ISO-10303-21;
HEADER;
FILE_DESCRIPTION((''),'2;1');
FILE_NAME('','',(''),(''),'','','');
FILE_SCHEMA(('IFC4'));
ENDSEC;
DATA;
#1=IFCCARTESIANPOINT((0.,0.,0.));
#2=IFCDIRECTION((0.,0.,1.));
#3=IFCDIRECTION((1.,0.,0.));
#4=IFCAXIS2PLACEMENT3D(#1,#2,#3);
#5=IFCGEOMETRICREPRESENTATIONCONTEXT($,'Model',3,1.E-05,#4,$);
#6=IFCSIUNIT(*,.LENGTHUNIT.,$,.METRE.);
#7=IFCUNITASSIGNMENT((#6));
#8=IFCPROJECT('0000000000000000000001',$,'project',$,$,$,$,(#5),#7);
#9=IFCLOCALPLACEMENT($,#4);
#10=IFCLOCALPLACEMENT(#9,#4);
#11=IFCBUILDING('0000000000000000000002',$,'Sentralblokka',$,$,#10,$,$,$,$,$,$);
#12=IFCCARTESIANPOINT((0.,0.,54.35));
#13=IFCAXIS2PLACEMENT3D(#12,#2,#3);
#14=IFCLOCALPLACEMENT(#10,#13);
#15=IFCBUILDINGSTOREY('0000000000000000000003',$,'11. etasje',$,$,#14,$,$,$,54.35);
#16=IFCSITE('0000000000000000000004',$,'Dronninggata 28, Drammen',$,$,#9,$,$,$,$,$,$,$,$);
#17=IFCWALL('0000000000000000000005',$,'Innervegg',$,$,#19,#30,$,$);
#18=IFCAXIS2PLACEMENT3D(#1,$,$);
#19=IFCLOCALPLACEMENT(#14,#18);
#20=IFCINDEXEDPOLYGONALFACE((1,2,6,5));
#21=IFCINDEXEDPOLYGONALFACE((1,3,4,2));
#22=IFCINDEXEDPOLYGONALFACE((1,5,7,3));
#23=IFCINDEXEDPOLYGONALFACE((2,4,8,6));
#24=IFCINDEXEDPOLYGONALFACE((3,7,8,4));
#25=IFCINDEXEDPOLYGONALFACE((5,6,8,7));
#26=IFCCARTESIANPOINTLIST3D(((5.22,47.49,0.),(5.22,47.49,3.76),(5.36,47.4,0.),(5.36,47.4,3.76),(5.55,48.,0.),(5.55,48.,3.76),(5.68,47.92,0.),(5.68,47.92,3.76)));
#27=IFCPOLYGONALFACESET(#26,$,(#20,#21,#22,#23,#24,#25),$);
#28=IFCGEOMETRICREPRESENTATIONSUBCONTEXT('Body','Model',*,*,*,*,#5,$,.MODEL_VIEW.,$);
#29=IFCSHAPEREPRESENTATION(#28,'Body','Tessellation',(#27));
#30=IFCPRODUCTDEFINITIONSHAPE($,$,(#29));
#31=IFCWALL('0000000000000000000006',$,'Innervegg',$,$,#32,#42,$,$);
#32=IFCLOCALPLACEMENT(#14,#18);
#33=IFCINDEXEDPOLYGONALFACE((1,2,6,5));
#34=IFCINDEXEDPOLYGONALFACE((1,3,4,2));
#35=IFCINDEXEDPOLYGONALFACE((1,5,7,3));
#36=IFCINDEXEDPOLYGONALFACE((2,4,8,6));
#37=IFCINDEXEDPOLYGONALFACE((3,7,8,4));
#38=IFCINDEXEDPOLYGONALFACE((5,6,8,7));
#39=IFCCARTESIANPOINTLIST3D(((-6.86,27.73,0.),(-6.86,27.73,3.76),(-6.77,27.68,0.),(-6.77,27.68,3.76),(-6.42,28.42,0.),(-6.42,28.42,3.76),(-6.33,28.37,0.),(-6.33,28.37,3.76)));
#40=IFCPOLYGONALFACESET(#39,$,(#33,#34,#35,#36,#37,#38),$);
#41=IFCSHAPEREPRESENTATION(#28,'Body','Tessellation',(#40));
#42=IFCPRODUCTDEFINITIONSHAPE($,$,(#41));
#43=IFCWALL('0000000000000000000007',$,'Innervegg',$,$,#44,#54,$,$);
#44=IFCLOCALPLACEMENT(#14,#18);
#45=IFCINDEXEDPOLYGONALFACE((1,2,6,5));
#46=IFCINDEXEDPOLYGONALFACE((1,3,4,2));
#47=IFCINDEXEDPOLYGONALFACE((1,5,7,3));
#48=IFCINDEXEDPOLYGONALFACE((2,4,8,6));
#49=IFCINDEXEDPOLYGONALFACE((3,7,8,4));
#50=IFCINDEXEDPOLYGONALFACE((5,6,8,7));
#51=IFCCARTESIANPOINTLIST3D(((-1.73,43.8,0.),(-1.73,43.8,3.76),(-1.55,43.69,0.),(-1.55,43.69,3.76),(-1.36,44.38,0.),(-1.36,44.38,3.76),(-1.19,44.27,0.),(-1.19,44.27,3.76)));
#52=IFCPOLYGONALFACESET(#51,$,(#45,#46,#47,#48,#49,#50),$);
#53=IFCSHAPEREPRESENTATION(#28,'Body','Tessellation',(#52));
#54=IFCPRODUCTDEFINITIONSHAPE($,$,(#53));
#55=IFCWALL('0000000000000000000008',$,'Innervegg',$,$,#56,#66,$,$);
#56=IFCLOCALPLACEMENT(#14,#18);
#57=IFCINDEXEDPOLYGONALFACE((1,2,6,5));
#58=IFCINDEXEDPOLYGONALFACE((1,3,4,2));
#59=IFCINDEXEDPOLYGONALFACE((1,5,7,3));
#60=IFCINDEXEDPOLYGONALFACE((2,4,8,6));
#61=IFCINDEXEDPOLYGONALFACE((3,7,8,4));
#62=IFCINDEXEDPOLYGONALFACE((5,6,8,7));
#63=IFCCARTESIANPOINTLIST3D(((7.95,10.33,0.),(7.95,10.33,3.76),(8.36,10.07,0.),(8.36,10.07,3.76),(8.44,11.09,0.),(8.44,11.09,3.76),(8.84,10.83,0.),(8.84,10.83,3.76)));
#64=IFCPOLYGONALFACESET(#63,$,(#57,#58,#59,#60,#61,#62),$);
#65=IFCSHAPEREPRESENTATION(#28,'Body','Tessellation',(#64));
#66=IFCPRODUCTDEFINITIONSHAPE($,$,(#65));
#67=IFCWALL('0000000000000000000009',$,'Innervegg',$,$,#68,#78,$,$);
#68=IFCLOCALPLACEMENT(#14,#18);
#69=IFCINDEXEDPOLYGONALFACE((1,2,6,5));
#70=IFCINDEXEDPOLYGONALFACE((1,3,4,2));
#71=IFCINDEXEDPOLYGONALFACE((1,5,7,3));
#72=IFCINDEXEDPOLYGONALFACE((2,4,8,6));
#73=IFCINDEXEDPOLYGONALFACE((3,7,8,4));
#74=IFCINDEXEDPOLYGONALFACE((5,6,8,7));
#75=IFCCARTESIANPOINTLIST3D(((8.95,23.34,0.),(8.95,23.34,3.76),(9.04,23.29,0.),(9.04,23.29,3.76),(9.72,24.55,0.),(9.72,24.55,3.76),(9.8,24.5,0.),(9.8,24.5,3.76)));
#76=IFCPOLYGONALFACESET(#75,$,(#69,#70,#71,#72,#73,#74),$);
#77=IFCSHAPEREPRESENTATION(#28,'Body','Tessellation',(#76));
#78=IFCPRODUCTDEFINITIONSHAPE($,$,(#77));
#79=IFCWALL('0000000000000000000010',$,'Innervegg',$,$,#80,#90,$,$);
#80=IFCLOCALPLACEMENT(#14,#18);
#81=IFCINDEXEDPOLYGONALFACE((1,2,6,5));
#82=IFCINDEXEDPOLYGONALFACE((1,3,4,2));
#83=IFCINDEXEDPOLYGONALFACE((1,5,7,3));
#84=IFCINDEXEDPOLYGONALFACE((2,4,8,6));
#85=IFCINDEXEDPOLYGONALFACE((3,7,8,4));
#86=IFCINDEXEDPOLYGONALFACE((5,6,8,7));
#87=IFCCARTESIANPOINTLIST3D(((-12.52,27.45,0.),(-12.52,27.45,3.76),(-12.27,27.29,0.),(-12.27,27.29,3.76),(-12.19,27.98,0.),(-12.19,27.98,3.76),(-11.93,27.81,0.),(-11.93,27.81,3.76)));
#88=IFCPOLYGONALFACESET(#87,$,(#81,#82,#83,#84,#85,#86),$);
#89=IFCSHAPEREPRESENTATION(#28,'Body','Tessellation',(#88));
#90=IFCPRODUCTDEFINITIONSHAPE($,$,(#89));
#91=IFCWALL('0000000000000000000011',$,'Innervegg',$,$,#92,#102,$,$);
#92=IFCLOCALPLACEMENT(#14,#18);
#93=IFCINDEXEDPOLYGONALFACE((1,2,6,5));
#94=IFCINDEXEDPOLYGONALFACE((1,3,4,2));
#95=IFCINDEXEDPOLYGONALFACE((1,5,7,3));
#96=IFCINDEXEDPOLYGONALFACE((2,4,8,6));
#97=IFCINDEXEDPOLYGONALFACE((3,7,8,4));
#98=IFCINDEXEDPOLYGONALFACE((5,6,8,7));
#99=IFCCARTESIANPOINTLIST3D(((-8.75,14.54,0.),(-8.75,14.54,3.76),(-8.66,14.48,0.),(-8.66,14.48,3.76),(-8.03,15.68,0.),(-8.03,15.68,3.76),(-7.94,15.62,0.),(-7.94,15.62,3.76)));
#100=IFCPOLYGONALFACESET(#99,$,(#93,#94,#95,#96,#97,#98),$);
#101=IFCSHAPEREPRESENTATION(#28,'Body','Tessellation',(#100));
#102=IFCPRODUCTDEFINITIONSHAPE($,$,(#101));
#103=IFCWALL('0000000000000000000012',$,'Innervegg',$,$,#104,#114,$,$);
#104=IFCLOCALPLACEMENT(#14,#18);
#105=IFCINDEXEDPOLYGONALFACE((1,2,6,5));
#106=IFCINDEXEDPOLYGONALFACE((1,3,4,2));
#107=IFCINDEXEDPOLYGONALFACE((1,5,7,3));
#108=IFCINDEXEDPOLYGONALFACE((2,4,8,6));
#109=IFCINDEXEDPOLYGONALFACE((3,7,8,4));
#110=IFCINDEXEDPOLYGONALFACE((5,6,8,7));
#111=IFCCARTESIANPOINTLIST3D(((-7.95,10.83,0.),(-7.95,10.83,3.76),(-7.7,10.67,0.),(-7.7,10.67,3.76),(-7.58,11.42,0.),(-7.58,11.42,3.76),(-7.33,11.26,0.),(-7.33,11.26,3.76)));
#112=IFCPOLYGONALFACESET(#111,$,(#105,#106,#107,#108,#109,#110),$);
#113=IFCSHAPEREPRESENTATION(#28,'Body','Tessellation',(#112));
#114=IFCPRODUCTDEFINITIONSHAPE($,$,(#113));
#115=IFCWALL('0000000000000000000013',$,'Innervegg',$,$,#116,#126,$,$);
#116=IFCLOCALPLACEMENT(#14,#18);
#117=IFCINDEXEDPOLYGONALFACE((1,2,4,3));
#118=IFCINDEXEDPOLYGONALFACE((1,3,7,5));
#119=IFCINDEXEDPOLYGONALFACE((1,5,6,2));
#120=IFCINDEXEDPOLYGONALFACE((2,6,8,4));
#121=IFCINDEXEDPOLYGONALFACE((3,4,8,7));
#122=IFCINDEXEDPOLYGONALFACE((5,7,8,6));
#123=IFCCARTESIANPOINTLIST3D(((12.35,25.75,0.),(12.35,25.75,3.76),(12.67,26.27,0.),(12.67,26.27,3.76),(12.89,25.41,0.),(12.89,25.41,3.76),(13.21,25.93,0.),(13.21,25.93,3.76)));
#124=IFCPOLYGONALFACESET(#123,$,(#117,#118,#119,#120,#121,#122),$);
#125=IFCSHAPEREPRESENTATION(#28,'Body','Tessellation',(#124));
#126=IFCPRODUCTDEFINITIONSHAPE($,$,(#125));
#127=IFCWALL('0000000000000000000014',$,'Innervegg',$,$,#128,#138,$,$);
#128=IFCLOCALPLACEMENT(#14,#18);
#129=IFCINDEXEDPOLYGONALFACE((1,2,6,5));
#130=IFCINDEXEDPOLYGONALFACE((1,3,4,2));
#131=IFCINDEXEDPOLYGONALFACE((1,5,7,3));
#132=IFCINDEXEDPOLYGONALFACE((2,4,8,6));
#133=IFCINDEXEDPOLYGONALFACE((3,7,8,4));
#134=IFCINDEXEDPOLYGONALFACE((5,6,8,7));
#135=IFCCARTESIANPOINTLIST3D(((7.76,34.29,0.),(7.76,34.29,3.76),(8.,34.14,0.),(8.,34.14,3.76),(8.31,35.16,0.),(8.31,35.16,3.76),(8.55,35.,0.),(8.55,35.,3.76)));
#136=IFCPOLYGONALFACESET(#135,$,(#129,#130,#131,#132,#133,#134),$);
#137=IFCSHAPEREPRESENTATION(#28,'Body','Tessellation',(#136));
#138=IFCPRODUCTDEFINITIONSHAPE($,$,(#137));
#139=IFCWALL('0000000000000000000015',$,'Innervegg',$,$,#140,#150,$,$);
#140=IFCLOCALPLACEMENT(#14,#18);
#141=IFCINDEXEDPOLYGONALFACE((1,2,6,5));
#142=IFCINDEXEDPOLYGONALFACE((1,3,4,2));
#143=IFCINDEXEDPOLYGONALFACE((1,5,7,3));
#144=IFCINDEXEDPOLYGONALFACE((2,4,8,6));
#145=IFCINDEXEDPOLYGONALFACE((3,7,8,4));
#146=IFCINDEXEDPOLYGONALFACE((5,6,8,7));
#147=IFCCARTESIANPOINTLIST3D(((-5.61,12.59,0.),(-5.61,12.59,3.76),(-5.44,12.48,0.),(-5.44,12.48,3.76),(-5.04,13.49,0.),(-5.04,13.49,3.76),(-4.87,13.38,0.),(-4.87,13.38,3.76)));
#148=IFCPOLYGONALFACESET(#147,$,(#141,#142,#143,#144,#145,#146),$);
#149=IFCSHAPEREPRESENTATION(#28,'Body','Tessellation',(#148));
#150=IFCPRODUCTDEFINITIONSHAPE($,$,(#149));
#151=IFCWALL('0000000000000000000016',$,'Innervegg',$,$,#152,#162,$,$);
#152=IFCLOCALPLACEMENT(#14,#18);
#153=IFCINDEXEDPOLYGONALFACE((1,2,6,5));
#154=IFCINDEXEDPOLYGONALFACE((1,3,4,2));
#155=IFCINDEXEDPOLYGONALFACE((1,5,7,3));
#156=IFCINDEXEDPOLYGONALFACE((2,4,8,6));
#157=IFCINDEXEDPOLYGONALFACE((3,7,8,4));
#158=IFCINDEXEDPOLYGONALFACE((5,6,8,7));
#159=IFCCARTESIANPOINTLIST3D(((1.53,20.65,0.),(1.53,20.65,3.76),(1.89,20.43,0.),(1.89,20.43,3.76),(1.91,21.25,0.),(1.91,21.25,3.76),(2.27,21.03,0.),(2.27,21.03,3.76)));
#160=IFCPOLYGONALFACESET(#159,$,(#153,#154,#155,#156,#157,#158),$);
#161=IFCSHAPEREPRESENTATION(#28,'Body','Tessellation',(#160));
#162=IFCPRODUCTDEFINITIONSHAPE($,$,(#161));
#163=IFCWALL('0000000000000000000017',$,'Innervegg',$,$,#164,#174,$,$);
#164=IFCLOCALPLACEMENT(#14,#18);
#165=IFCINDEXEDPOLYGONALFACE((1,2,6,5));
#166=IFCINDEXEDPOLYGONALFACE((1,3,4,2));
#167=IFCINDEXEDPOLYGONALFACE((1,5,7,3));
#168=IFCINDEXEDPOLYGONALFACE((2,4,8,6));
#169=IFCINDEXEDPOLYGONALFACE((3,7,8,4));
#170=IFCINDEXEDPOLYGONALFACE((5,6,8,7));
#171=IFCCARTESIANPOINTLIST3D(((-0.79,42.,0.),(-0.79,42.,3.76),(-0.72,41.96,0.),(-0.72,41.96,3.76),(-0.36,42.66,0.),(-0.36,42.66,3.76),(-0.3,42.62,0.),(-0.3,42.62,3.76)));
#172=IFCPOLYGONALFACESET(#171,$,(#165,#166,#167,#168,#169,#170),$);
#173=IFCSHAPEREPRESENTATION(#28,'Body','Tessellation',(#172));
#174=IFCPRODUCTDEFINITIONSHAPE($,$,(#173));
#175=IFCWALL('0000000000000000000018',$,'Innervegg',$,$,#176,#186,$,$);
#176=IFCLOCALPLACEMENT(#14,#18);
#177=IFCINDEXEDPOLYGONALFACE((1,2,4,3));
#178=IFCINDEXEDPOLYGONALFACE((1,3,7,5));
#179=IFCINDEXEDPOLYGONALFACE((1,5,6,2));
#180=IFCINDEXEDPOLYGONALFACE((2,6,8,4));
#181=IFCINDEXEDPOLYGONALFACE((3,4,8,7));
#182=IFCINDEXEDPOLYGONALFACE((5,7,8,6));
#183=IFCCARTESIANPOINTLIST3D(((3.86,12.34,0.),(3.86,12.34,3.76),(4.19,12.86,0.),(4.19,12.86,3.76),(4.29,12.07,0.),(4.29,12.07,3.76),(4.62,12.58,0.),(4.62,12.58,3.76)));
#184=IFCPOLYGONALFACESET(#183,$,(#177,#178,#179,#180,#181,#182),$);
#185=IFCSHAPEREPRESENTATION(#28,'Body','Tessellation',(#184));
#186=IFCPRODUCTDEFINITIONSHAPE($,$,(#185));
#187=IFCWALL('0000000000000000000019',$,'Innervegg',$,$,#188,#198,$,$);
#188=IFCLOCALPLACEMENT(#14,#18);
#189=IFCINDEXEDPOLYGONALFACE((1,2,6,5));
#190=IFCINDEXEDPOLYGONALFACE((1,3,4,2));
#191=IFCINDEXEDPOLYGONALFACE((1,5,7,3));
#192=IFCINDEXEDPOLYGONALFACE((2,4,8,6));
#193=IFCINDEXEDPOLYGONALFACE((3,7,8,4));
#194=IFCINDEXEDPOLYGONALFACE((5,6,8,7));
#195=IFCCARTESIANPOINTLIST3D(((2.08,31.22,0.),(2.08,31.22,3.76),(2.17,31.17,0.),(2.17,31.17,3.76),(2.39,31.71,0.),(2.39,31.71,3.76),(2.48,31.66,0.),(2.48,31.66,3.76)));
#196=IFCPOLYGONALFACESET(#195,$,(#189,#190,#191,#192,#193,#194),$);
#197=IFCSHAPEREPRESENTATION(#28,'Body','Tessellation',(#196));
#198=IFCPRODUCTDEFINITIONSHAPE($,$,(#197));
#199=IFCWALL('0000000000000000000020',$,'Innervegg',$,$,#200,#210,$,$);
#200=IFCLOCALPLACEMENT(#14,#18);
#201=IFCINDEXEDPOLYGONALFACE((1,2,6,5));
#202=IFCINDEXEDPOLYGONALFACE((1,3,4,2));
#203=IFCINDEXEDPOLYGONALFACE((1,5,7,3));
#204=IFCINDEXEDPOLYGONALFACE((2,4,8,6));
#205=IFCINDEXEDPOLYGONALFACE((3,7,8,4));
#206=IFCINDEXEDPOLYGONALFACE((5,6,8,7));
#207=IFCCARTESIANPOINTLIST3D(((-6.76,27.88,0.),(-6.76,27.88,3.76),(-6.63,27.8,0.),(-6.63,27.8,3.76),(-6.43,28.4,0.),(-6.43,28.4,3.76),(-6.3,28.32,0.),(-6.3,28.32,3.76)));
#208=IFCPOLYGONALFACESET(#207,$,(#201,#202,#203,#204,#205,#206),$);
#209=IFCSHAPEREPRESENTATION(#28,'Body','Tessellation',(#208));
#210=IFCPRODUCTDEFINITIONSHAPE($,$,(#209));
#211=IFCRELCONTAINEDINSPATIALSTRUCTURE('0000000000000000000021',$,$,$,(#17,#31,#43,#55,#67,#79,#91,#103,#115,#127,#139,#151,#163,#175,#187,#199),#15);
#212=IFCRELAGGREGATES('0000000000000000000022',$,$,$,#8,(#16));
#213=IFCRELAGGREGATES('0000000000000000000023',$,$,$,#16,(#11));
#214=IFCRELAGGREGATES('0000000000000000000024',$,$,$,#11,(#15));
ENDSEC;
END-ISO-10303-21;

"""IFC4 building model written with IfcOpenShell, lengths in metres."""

from ifc_helpers import new_model, si_unit, frame, origin_with_axes, place, context, subcontext, project, spatial, polyline, outline, extrude, element, save


model = new_model("IFC4")

# Units and contexts
model_context = context("Model", 3, precision=1e-05, world=origin_with_axes())
body_context = subcontext(model_context, "Body", "Model", "MODEL_VIEW")
ifc_project = project(units=[si_unit("LENGTHUNIT", "METRE")], contexts=[model_context])

# Site, building, storey
site_placement = place(None, origin_with_axes())
site = spatial("IfcSite", under=ifc_project, at=site_placement, Name="Dronninggata 28, Drammen")
building_placement = place(site_placement, origin_with_axes())
building = spatial("IfcBuilding", under=site, at=building_placement, Name="Sentralblokka")
storey_placement = place(building_placement, frame((0.0, 0.0, 54.35), z_axis=(0.0, 0.0, 1.0), x_axis=(1.0, 0.0, 0.0)))
storey = spatial("IfcBuildingStorey", under=building, at=storey_placement, Name="11. etasje", Elevation=54.35)

# Walls
wall_1_placement = place(storey_placement, frame((0.0, 0.0, -54.35), z_axis=(0.0, 0.0, 1.0), x_axis=(1.0, 0.0, 0.0)))
element("IfcWall", 1, at=wall_1_placement, inside=storey, Name="Innervegg", context=body_context, shape_type="SweptSolid", body=[
    extrude(outline(polyline([(5.68, 47.92), (5.36, 47.4), (5.22, 47.49), (5.55, 48.0), (5.68, 47.92)])), frame((0.0, 0.0, 54.35)), (0.0, 0.0, 1.0), 3.76),
])
wall_2_placement = place(storey_placement, frame((0.0, 0.0, -54.35), z_axis=(0.0, 0.0, 1.0), x_axis=(1.0, 0.0, 0.0)))
element("IfcWall", 2, at=wall_2_placement, inside=storey, Name="Innervegg", context=body_context, shape_type="SweptSolid", body=[
    extrude(outline(polyline([(-6.33, 28.37), (-6.77, 27.68), (-6.86, 27.73), (-6.42, 28.42), (-6.33, 28.37)])), frame((0.0, 0.0, 54.35)), (0.0, 0.0, 1.0), 3.76),
])
wall_3_placement = place(storey_placement, frame((0.0, 0.0, -54.35), z_axis=(0.0, 0.0, 1.0), x_axis=(1.0, 0.0, 0.0)))
element("IfcWall", 3, at=wall_3_placement, inside=storey, Name="Innervegg", context=body_context, shape_type="SweptSolid", body=[
    extrude(outline(polyline([(-1.19, 44.27), (-1.55, 43.69), (-1.73, 43.8), (-1.36, 44.38), (-1.19, 44.27)])), frame((0.0, 0.0, 54.35)), (0.0, 0.0, 1.0), 3.76),
])
wall_4_placement = place(storey_placement, frame((0.0, 0.0, -54.35), z_axis=(0.0, 0.0, 1.0), x_axis=(1.0, 0.0, 0.0)))
element("IfcWall", 4, at=wall_4_placement, inside=storey, Name="Innervegg", context=body_context, shape_type="SweptSolid", body=[
    extrude(outline(polyline([(8.84, 10.83), (8.36, 10.07), (7.95, 10.33), (8.44, 11.09), (8.84, 10.83)])), frame((0.0, 0.0, 54.35)), (0.0, 0.0, 1.0), 3.76),
])
wall_5_placement = place(storey_placement, frame((0.0, 0.0, -54.35), z_axis=(0.0, 0.0, 1.0), x_axis=(1.0, 0.0, 0.0)))
element("IfcWall", 5, at=wall_5_placement, inside=storey, Name="Innervegg", context=body_context, shape_type="SweptSolid", body=[
    extrude(outline(polyline([(9.8, 24.5), (9.04, 23.29), (8.95, 23.34), (9.72, 24.55), (9.8, 24.5)])), frame((0.0, 0.0, 54.35)), (0.0, 0.0, 1.0), 3.76),
])
wall_6_placement = place(storey_placement, frame((0.0, 0.0, -54.35), z_axis=(0.0, 0.0, 1.0), x_axis=(1.0, 0.0, 0.0)))
element("IfcWall", 6, at=wall_6_placement, inside=storey, Name="Innervegg", context=body_context, shape_type="SweptSolid", body=[
    extrude(outline(polyline([(-11.93, 27.81), (-12.27, 27.29), (-12.52, 27.45), (-12.19, 27.98), (-11.93, 27.81)])), frame((0.0, 0.0, 54.35)), (0.0, 0.0, 1.0), 3.76),
])
wall_7_placement = place(storey_placement, frame((0.0, 0.0, -54.35), z_axis=(0.0, 0.0, 1.0), x_axis=(1.0, 0.0, 0.0)))
element("IfcWall", 7, at=wall_7_placement, inside=storey, Name="Innervegg", context=body_context, shape_type="SweptSolid", body=[
    extrude(outline(polyline([(-7.94, 15.62), (-8.66, 14.48), (-8.75, 14.54), (-8.03, 15.68), (-7.94, 15.62)])), frame((0.0, 0.0, 54.35)), (0.0, 0.0, 1.0), 3.76),
])
wall_8_placement = place(storey_placement, frame((0.0, 0.0, -54.35), z_axis=(0.0, 0.0, 1.0), x_axis=(1.0, 0.0, 0.0)))
element("IfcWall", 8, at=wall_8_placement, inside=storey, Name="Innervegg", context=body_context, shape_type="SweptSolid", body=[
    extrude(outline(polyline([(-7.33, 11.26), (-7.7, 10.67), (-7.95, 10.83), (-7.58, 11.42), (-7.33, 11.26)])), frame((0.0, 0.0, 54.35)), (0.0, 0.0, 1.0), 3.76),
])
wall_9_placement = place(storey_placement, frame((0.0, 0.0, -54.35), z_axis=(0.0, 0.0, 1.0), x_axis=(1.0, 0.0, 0.0)))
element("IfcWall", 9, at=wall_9_placement, inside=storey, Name="Innervegg", context=body_context, shape_type="SweptSolid", body=[
    extrude(outline(polyline([(13.21, 25.93), (12.89, 25.41), (12.35, 25.75), (12.67, 26.27), (13.21, 25.93)])), frame((0.0, 0.0, 54.35)), (0.0, 0.0, 1.0), 3.76),
])
wall_10_placement = place(storey_placement, frame((0.0, 0.0, -54.35), z_axis=(0.0, 0.0, 1.0), x_axis=(1.0, 0.0, 0.0)))
element("IfcWall", 10, at=wall_10_placement, inside=storey, Name="Innervegg", context=body_context, shape_type="SweptSolid", body=[
    extrude(outline(polyline([(8.55, 35.0), (8.0, 34.14), (7.76, 34.29), (8.31, 35.16), (8.55, 35.0)])), frame((0.0, 0.0, 54.35)), (0.0, 0.0, 1.0), 3.76),
])
wall_11_placement = place(storey_placement, frame((0.0, 0.0, -54.35), z_axis=(0.0, 0.0, 1.0), x_axis=(1.0, 0.0, 0.0)))
element("IfcWall", 11, at=wall_11_placement, inside=storey, Name="Innervegg", context=body_context, shape_type="SweptSolid", body=[
    extrude(outline(polyline([(-4.87, 13.38), (-5.44, 12.48), (-5.61, 12.59), (-5.04, 13.49), (-4.87, 13.38)])), frame((0.0, 0.0, 54.35)), (0.0, 0.0, 1.0), 3.76),
])
wall_12_placement = place(storey_placement, frame((0.0, 0.0, -54.35), z_axis=(0.0, 0.0, 1.0), x_axis=(1.0, 0.0, 0.0)))
element("IfcWall", 12, at=wall_12_placement, inside=storey, Name="Innervegg", context=body_context, shape_type="SweptSolid", body=[
    extrude(outline(polyline([(2.27, 21.03), (1.89, 20.43), (1.53, 20.65), (1.91, 21.25), (2.27, 21.03)])), frame((0.0, 0.0, 54.35)), (0.0, 0.0, 1.0), 3.76),
])
wall_13_placement = place(storey_placement, frame((0.0, 0.0, -54.35), z_axis=(0.0, 0.0, 1.0), x_axis=(1.0, 0.0, 0.0)))
element("IfcWall", 13, at=wall_13_placement, inside=storey, Name="Innervegg", context=body_context, shape_type="SweptSolid", body=[
    extrude(outline(polyline([(-0.3, 42.62), (-0.72, 41.96), (-0.79, 42.0), (-0.36, 42.66), (-0.3, 42.62)])), frame((0.0, 0.0, 54.35)), (0.0, 0.0, 1.0), 3.76),
])
wall_14_placement = place(storey_placement, frame((0.0, 0.0, -54.35), z_axis=(0.0, 0.0, 1.0), x_axis=(1.0, 0.0, 0.0)))
element("IfcWall", 14, at=wall_14_placement, inside=storey, Name="Innervegg", context=body_context, shape_type="SweptSolid", body=[
    extrude(outline(polyline([(4.62, 12.58), (4.29, 12.07), (3.86, 12.34), (4.19, 12.86), (4.62, 12.58)])), frame((0.0, 0.0, 54.35)), (0.0, 0.0, 1.0), 3.76),
])
wall_15_placement = place(storey_placement, frame((0.0, 0.0, -54.35), z_axis=(0.0, 0.0, 1.0), x_axis=(1.0, 0.0, 0.0)))
element("IfcWall", 15, at=wall_15_placement, inside=storey, Name="Innervegg", context=body_context, shape_type="SweptSolid", body=[
    extrude(outline(polyline([(2.48, 31.66), (2.17, 31.17), (2.08, 31.22), (2.39, 31.71), (2.48, 31.66)])), frame((0.0, 0.0, 54.35)), (0.0, 0.0, 1.0), 3.76),
])
wall_16_placement = place(storey_placement, frame((0.0, 0.0, -54.35), z_axis=(0.0, 0.0, 1.0), x_axis=(1.0, 0.0, 0.0)))
element("IfcWall", 16, at=wall_16_placement, inside=storey, Name="Innervegg", context=body_context, shape_type="SweptSolid", body=[
    extrude(outline(polyline([(-6.3, 28.32), (-6.63, 27.8), (-6.76, 27.88), (-6.43, 28.4), (-6.3, 28.32)])), frame((0.0, 0.0, 54.35)), (0.0, 0.0, 1.0), 3.76),
])

save(model, "model.ifc")
